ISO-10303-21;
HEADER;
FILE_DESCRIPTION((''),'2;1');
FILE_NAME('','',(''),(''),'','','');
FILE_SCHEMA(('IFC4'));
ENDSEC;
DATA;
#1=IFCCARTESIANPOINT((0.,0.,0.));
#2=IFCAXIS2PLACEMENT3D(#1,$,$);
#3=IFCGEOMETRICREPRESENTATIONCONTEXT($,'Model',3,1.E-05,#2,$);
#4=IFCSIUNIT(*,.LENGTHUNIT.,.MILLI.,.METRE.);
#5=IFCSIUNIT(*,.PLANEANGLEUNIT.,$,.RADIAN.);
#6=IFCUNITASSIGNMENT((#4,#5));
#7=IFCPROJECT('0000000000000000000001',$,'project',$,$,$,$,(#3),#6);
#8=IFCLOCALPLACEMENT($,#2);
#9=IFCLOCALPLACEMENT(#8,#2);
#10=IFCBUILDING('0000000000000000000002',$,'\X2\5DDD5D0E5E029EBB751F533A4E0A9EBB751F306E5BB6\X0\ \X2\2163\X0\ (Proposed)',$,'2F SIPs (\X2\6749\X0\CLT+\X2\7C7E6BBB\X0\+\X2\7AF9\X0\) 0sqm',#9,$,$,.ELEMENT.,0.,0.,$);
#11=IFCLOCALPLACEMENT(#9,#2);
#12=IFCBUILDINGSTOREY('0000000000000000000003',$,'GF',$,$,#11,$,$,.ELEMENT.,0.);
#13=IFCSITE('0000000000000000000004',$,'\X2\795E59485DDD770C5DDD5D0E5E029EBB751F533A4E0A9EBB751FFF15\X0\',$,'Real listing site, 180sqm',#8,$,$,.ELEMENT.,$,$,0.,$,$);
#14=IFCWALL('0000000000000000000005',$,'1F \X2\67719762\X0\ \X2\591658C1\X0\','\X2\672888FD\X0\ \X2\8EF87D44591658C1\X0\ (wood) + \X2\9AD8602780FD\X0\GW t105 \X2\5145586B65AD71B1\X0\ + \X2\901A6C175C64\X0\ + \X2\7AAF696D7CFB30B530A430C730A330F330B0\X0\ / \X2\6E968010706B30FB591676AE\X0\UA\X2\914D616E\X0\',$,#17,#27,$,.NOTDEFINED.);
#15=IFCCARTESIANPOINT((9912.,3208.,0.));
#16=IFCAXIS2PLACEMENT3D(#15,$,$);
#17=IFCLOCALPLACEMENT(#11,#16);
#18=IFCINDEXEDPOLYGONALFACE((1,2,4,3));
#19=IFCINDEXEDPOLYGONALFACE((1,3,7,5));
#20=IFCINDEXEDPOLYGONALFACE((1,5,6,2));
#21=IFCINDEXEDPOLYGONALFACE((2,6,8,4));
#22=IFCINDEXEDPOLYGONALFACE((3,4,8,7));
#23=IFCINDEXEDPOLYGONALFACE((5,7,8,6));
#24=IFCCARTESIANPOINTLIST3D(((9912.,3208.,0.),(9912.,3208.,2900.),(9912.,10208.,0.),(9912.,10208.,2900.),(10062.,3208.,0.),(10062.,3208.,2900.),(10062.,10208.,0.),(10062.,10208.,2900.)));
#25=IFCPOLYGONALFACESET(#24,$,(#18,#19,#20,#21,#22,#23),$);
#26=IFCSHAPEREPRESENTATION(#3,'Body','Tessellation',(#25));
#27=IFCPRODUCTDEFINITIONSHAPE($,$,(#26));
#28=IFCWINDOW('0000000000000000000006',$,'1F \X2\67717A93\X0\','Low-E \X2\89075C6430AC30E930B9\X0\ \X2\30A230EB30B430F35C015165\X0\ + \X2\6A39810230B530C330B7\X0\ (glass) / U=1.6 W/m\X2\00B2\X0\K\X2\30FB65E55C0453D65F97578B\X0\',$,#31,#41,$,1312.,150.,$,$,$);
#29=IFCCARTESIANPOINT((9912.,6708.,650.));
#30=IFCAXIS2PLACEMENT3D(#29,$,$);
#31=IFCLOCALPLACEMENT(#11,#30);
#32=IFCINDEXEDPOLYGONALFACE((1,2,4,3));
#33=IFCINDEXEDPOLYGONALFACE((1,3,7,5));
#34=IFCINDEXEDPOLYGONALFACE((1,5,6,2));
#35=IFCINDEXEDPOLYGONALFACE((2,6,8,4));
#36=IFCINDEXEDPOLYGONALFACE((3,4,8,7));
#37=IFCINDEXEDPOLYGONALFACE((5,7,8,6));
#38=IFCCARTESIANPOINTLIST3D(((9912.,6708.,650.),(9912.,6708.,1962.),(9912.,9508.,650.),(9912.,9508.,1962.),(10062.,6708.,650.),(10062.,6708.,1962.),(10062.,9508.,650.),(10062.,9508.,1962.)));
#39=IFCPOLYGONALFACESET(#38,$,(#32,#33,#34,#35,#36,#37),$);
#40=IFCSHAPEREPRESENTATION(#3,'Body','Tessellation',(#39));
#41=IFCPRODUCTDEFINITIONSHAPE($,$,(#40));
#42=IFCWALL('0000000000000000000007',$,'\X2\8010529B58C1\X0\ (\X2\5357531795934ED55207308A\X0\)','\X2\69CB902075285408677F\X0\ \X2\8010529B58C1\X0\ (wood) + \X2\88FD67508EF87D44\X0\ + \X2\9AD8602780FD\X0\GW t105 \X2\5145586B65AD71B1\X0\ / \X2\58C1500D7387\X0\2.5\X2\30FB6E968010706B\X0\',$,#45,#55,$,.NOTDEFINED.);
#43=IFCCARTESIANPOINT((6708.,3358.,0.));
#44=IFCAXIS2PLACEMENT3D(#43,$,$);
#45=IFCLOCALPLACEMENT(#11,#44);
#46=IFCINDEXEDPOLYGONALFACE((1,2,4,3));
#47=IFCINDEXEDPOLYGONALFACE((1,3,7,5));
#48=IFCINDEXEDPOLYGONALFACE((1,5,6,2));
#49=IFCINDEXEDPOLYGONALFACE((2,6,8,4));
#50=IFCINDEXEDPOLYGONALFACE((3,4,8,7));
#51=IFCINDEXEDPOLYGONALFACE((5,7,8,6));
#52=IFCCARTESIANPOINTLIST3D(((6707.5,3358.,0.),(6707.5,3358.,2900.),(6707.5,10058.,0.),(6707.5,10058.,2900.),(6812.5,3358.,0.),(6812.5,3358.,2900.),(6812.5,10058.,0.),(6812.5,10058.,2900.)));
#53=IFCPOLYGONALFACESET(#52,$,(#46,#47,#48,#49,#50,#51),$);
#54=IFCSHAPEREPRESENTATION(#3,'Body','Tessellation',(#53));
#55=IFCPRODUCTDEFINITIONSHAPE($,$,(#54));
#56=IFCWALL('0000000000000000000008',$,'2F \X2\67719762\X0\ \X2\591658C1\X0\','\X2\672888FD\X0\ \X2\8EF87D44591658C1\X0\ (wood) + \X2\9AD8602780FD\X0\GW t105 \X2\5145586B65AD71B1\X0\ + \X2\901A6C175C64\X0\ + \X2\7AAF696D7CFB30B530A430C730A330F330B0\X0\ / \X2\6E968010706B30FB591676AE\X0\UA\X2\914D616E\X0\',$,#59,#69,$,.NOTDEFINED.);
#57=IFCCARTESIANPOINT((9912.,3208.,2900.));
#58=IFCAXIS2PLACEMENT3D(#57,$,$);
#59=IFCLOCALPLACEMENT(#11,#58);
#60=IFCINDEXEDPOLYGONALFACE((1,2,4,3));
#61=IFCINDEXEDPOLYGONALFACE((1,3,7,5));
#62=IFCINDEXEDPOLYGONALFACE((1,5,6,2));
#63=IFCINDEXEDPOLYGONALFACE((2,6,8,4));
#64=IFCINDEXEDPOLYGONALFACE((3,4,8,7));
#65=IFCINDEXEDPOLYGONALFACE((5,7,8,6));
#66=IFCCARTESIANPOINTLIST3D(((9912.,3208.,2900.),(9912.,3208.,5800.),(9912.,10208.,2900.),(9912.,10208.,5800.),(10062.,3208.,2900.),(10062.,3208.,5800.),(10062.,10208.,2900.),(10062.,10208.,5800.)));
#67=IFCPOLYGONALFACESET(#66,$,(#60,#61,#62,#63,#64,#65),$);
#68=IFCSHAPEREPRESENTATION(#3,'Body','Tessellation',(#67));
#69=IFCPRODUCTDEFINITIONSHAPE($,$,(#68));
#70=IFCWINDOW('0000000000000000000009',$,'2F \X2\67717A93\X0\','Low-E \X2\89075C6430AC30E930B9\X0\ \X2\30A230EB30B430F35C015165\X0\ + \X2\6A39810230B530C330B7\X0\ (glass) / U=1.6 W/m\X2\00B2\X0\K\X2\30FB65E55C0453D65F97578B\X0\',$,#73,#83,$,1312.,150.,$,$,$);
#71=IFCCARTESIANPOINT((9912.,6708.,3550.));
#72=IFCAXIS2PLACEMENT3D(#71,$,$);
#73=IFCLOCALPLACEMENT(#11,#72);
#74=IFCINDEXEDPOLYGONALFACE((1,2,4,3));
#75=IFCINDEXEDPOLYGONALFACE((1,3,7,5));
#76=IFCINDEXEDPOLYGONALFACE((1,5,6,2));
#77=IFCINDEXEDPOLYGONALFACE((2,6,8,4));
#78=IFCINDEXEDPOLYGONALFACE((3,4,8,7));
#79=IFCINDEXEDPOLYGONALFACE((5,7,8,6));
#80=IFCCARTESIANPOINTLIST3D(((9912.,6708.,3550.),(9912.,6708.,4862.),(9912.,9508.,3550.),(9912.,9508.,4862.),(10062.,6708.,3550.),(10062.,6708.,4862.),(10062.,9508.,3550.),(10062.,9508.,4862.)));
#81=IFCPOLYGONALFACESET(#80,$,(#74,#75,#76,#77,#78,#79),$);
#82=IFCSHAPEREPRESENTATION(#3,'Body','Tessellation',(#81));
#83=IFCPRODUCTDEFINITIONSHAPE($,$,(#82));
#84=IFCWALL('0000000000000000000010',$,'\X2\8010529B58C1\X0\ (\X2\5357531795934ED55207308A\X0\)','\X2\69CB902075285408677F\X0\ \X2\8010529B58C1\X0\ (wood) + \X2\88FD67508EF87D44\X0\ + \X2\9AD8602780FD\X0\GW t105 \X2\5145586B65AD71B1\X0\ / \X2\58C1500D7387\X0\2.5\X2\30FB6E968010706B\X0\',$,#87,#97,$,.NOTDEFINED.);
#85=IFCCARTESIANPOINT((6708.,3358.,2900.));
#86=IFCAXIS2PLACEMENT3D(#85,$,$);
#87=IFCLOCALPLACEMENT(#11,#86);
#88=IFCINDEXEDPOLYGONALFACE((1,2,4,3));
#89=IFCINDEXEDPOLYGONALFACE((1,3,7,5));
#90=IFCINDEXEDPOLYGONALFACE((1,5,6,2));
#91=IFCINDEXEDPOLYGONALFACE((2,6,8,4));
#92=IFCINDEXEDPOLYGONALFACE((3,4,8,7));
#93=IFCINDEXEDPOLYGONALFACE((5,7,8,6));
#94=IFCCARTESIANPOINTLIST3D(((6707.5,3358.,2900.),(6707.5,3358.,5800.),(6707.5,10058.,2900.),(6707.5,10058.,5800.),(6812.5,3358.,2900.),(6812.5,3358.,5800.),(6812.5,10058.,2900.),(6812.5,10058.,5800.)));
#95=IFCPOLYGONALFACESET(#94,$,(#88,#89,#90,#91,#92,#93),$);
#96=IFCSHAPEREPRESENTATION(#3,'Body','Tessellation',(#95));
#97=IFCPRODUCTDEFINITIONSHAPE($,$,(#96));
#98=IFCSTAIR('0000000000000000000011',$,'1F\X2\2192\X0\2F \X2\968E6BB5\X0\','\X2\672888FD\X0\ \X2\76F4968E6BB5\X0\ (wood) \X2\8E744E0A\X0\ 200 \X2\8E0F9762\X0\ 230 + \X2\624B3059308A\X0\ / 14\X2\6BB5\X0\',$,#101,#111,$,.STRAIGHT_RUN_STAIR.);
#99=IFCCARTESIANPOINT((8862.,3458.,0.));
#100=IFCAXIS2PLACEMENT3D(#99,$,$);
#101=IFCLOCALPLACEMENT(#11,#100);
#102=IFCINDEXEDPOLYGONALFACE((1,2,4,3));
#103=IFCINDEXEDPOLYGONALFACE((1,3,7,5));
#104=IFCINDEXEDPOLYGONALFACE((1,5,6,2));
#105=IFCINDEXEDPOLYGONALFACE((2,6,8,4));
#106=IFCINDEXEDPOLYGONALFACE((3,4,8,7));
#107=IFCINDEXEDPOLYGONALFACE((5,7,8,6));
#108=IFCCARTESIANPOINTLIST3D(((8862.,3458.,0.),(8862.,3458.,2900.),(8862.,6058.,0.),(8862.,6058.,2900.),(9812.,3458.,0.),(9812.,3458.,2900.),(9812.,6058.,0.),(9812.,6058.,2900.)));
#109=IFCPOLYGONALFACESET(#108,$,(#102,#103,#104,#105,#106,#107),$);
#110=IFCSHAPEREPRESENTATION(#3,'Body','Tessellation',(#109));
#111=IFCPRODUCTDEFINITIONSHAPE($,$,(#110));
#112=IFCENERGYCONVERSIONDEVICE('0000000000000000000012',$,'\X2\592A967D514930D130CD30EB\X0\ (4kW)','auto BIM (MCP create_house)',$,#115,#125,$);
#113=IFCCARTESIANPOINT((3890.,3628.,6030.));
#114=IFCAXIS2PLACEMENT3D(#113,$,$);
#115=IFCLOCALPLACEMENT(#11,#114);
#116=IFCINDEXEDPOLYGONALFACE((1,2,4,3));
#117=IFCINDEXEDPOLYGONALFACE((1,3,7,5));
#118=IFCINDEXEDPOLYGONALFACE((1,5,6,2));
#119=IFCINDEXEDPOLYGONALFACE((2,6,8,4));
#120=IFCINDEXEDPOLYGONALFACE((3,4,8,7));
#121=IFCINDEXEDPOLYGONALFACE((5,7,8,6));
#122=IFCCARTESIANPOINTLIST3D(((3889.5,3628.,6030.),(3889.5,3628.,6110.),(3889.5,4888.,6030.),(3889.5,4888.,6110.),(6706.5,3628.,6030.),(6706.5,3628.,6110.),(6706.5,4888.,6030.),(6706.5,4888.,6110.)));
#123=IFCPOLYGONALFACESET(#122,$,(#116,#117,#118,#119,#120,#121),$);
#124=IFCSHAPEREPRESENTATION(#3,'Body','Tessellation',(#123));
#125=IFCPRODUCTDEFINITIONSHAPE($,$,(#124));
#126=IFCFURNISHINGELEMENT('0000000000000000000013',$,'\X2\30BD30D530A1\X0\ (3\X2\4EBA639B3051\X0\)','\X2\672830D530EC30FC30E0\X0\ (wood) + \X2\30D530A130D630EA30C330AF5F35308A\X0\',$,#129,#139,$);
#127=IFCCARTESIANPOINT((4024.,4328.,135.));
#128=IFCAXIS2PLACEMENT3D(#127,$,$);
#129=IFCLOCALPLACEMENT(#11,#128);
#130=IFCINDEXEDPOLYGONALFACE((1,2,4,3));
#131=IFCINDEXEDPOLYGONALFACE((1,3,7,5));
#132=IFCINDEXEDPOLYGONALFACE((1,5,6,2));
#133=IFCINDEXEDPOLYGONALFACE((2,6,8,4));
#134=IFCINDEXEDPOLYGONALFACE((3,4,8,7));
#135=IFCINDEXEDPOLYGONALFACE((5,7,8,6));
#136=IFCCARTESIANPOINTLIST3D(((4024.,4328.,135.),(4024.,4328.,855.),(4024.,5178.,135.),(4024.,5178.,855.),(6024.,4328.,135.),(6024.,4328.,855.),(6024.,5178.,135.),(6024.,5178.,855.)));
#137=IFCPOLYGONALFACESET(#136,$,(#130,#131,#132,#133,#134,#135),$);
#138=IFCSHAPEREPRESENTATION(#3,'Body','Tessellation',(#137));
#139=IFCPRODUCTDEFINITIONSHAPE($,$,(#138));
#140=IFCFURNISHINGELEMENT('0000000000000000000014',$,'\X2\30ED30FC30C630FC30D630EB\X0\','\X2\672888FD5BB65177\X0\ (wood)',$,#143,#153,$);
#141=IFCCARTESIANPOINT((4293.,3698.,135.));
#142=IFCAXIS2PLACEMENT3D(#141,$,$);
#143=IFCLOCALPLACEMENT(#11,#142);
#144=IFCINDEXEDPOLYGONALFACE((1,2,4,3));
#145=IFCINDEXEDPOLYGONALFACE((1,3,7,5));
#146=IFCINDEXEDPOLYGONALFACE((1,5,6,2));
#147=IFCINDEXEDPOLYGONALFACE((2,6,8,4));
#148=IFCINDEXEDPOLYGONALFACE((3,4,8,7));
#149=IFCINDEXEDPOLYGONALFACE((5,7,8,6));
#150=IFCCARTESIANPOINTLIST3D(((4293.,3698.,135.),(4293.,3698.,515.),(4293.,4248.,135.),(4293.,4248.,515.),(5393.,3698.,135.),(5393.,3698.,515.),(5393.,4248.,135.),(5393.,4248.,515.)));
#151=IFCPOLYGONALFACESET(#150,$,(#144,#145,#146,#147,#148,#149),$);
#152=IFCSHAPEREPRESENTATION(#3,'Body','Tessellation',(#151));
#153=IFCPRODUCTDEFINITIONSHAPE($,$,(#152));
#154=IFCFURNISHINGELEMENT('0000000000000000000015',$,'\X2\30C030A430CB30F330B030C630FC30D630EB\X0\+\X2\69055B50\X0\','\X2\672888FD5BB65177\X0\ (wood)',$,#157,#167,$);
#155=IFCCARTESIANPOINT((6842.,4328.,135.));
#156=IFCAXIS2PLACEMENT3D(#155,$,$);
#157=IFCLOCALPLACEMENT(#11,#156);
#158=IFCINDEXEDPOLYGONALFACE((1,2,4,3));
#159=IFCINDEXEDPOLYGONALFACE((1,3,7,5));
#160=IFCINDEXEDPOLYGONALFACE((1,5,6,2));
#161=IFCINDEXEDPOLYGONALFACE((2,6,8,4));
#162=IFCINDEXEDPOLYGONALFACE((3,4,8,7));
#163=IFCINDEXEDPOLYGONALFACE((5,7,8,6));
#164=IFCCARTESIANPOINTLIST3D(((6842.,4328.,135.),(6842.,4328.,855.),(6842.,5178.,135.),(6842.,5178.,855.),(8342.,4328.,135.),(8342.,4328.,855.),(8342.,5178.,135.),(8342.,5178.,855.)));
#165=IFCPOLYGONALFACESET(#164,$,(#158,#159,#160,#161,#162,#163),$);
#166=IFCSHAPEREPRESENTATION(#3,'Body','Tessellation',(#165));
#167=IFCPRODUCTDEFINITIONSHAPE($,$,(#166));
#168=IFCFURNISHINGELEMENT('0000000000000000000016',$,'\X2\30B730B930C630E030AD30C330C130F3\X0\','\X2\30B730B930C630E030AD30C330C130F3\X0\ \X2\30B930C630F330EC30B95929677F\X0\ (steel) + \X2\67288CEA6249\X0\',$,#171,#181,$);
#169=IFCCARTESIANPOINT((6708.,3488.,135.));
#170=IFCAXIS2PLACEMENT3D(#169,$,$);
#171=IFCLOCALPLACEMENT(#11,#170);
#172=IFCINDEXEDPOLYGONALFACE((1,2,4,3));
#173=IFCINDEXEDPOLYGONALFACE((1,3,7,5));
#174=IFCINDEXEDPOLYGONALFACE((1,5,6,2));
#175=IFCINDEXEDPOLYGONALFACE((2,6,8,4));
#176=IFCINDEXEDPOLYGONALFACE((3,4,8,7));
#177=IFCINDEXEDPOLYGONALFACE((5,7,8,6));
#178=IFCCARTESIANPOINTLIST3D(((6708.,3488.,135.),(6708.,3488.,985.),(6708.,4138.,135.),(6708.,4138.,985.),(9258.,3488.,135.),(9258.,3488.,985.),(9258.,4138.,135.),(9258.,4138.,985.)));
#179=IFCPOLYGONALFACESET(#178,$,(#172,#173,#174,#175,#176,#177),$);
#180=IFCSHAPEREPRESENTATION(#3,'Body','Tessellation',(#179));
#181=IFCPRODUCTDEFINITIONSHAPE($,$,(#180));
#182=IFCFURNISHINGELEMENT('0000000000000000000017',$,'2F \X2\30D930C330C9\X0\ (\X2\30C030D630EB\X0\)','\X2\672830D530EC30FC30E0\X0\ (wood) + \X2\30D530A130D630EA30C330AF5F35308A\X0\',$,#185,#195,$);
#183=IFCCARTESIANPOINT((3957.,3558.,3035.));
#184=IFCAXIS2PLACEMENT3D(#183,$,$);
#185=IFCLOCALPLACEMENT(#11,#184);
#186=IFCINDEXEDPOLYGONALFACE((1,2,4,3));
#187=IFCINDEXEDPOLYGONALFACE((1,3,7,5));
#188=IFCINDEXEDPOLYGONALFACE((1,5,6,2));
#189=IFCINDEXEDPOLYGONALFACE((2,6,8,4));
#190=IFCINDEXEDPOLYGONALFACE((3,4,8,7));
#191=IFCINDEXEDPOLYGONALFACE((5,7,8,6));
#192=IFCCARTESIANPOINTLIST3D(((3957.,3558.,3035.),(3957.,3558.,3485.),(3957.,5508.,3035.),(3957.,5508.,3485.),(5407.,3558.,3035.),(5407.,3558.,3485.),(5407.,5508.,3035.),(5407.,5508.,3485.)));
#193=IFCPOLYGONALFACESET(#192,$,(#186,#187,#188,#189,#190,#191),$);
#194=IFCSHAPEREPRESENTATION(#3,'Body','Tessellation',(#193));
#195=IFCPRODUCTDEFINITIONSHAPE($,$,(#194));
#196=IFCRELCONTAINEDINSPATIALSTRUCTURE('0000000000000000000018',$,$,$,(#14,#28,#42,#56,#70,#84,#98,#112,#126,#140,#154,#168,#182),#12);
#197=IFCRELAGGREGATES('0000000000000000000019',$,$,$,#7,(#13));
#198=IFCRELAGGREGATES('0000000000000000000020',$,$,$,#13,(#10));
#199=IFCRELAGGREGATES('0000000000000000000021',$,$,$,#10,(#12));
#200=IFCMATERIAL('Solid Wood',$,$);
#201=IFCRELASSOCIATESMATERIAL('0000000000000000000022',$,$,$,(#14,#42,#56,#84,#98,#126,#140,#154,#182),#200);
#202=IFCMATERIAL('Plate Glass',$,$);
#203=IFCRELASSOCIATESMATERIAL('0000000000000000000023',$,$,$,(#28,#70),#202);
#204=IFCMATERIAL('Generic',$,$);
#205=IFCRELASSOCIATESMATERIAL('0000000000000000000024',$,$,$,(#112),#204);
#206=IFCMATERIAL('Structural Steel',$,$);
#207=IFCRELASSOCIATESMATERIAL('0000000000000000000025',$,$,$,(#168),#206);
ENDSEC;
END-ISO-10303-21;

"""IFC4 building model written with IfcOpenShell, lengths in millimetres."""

from ifc_helpers import new_model, si_unit, frame, frame_2d, origin, place, context, project, spatial, rectangle, extrude, material, element, fill, save


model = new_model("IFC4")

# Units and contexts
model_context = context("Model", 3, precision=1e-05, world=origin())
ifc_project = project(units=[si_unit("LENGTHUNIT", "METRE", prefix="MILLI"), si_unit("PLANEANGLEUNIT", "RADIAN")], contexts=[model_context])

# Site, building, storey
site_placement = place(None, origin())
site = spatial("IfcSite", under=ifc_project, at=site_placement, Name="神奈川県川崎市麻生区上麻生５", ObjectType="Real listing site, 180sqm", CompositionType="ELEMENT", RefElevation=0.0)
building_placement = place(site_placement, origin())
building = spatial("IfcBuilding", under=site, at=building_placement, Name="川崎市麻生区上麻生の家 Ⅳ (Proposed)", ObjectType="2F SIPs (杉CLT+籾殻+竹) 0sqm", CompositionType="ELEMENT", ElevationOfRefHeight=0.0, ElevationOfTerrain=0.0)
storey_placement = place(building_placement, origin())
storey = spatial("IfcBuildingStorey", under=building, at=storey_placement, Name="GF", CompositionType="ELEMENT", Elevation=0.0)

# Wall, opening, window
ifc_material_1 = material(Name="Solid Wood")
wall_1_placement = place(storey_placement, frame((9912.0, 3208.0, 0.0)))
wall_1 = element("IfcWall", 1, at=wall_1_placement, inside=storey, material=ifc_material_1, Name="1F 東面 外壁", Description="木製 軸組外壁 (wood) + 高性能GW t105 充填断熱 + 通気層 + 窯業系サイディング / 準耐火・外皮UA配慮", PredefinedType="NOTDEFINED", context=model_context, shape_type="SweptSolid", body=[
    extrude(rectangle(XDim=150.0, YDim=7000.0, at=frame_2d((75.0, 3500.0))), frame((9912.0, 3208.0, 0.0)), (0.0, 0.0, 1.0), 2900.0),
])
opening_1_placement = place(storey_placement, frame((9912.0, 6708.0, 650.0)))
opening_1 = element("IfcOpeningElement", 2, at=opening_1_placement, cuts=wall_1, PredefinedType="NOTDEFINED", context=model_context, shape_type="SweptSolid", body=[
    extrude(rectangle(XDim=150.0, YDim=2800.0, at=frame_2d((75.0, 1400.0))), frame((9912.0, 6708.0, 650.0)), (0.0, 0.0, 1.0), 1312.0),
])
ifc_material_2 = material(Name="Plate Glass")
window_1_placement = place(storey_placement, frame((9912.0, 6708.0, 650.0)))
window_1 = element("IfcWindow", 3, at=window_1_placement, inside=storey, material=ifc_material_2, Name="1F 東窓", Description="Low-E 複層ガラス アルゴン封入 + 樹脂サッシ (glass) / U=1.6 W/m²K・日射取得型", OverallHeight=1312.0, OverallWidth=150.0, context=model_context, shape_type="SweptSolid", body=[
    extrude(rectangle(XDim=150.0, YDim=2800.0, at=frame_2d((75.0, 1400.0))), frame((9912.0, 6708.0, 650.0)), (0.0, 0.0, 1.0), 1312.0),
])
fill(opening_1, window_1)

# Wall
wall_2_placement = place(storey_placement, frame((6708.0, 3358.0, 0.0)))
element("IfcWall", 4, at=wall_2_placement, inside=storey, material=ifc_material_1, Name="耐力壁 (南北間仕切り)", Description="構造用合板 耐力壁 (wood) + 製材軸組 + 高性能GW t105 充填断熱 / 壁倍率2.5・準耐火", PredefinedType="NOTDEFINED", context=model_context, shape_type="SweptSolid", body=[
    extrude(rectangle(XDim=105.0, YDim=6700.0, at=frame_2d((52.0, 3350.0))), frame((6708.0, 3358.0, 0.0)), (0.0, 0.0, 1.0), 2900.0),
])

# Wall, opening, window
wall_3_placement = place(storey_placement, frame((9912.0, 3208.0, 2900.0)))
wall_3 = element("IfcWall", 5, at=wall_3_placement, inside=storey, material=ifc_material_1, Name="2F 東面 外壁", Description="木製 軸組外壁 (wood) + 高性能GW t105 充填断熱 + 通気層 + 窯業系サイディング / 準耐火・外皮UA配慮", PredefinedType="NOTDEFINED", context=model_context, shape_type="SweptSolid", body=[
    extrude(rectangle(XDim=150.0, YDim=7000.0, at=frame_2d((75.0, 3500.0))), frame((9912.0, 3208.0, 2900.0)), (0.0, 0.0, 1.0), 2900.0),
])
opening_2_placement = place(storey_placement, frame((9912.0, 6708.0, 3550.0)))
opening_2 = element("IfcOpeningElement", 6, at=opening_2_placement, cuts=wall_3, PredefinedType="NOTDEFINED", context=model_context, shape_type="SweptSolid", body=[
    extrude(rectangle(XDim=150.0, YDim=2800.0, at=frame_2d((75.0, 1400.0))), frame((9912.0, 6708.0, 3550.0)), (0.0, 0.0, 1.0), 1312.0),
])
window_2_placement = place(storey_placement, frame((9912.0, 6708.0, 3550.0)))
window_2 = element("IfcWindow", 7, at=window_2_placement, inside=storey, material=ifc_material_2, Name="2F 東窓", Description="Low-E 複層ガラス アルゴン封入 + 樹脂サッシ (glass) / U=1.6 W/m²K・日射取得型", OverallHeight=1312.0, OverallWidth=150.0, context=model_context, shape_type="SweptSolid", body=[
    extrude(rectangle(XDim=150.0, YDim=2800.0, at=frame_2d((75.0, 1400.0))), frame((9912.0, 6708.0, 3550.0)), (0.0, 0.0, 1.0), 1312.0),
])
fill(opening_2, window_2)

# Wall
wall_4_placement = place(storey_placement, frame((6708.0, 3358.0, 2900.0)))
element("IfcWall", 8, at=wall_4_placement, inside=storey, material=ifc_material_1, Name="耐力壁 (南北間仕切り)", Description="構造用合板 耐力壁 (wood) + 製材軸組 + 高性能GW t105 充填断熱 / 壁倍率2.5・準耐火", PredefinedType="NOTDEFINED", context=model_context, shape_type="SweptSolid", body=[
    extrude(rectangle(XDim=105.0, YDim=6700.0, at=frame_2d((52.0, 3350.0))), frame((6708.0, 3358.0, 2900.0)), (0.0, 0.0, 1.0), 2900.0),
])

# Stair
stair_placement = place(storey_placement, frame((8862.0, 3458.0, 0.0)))
element("IfcStair", 9, at=stair_placement, inside=storey, material=ifc_material_1, Name="1F→2F 階段", Description="木製 直階段 (wood) 蹴上 200 踏面 230 + 手すり / 14段", PredefinedType="STRAIGHT_RUN_STAIR", context=model_context, shape_type="SweptSolid", body=[
    extrude(rectangle(XDim=950.0, YDim=2600.0, at=frame_2d((475.0, 1300.0))), frame((8862.0, 3458.0, 0.0)), (0.0, 0.0, 1.0), 2900.0),
])

# Energy conversion device
ifc_material_3 = material(Name="Generic")
energy_conversion_device_placement = place(storey_placement, frame((3890.0, 3628.0, 6030.0)))
element("IfcEnergyConversionDevice", 10, at=energy_conversion_device_placement, inside=storey, material=ifc_material_3, Name="太陽光パネル (4kW)", Description="auto BIM (MCP create_house)", context=model_context, shape_type="SweptSolid", body=[
    extrude(rectangle(XDim=2817.0, YDim=1260.0, at=frame_2d((1408.0, 630.0))), frame((3890.0, 3628.0, 6030.0)), (0.0, 0.0, 1.0), 80.0),
])

# Furnishing elements
furnishing_1_placement = place(storey_placement, frame((4024.0, 4328.0, 135.0)))
element("IfcFurnishingElement", 11, at=furnishing_1_placement, inside=storey, material=ifc_material_1, Name="ソファ (3人掛け)", Description="木フレーム (wood) + ファブリック張り", context=model_context, shape_type="SweptSolid", body=[
    extrude(rectangle(XDim=2000.0, YDim=850.0, at=frame_2d((1000.0, 425.0))), frame((4024.0, 4328.0, 135.0)), (0.0, 0.0, 1.0), 720.0),
])
furnishing_2_placement = place(storey_placement, frame((4293.0, 3698.0, 135.0)))
element("IfcFurnishingElement", 12, at=furnishing_2_placement, inside=storey, material=ifc_material_1, Name="ローテーブル", Description="木製家具 (wood)", context=model_context, shape_type="SweptSolid", body=[
    extrude(rectangle(XDim=1100.0, YDim=550.0, at=frame_2d((550.0, 275.0))), frame((4293.0, 3698.0, 135.0)), (0.0, 0.0, 1.0), 380.0),
])
furnishing_3_placement = place(storey_placement, frame((6842.0, 4328.0, 135.0)))
element("IfcFurnishingElement", 13, at=furnishing_3_placement, inside=storey, material=ifc_material_1, Name="ダイニングテーブル+椅子", Description="木製家具 (wood)", context=model_context, shape_type="SweptSolid", body=[
    extrude(rectangle(XDim=1500.0, YDim=850.0, at=frame_2d((750.0, 425.0))), frame((6842.0, 4328.0, 135.0)), (0.0, 0.0, 1.0), 720.0),
])
ifc_material_4 = material(Name="Structural Steel")
furnishing_4_placement = place(storey_placement, frame((6708.0, 3488.0, 135.0)))
element("IfcFurnishingElement", 14, at=furnishing_4_placement, inside=storey, material=ifc_material_4, Name="システムキッチン", Description="システムキッチン ステンレス天板 (steel) + 木質扉", context=model_context, shape_type="SweptSolid", body=[
    extrude(rectangle(XDim=2550.0, YDim=650.0, at=frame_2d((1275.0, 325.0))), frame((6708.0, 3488.0, 135.0)), (0.0, 0.0, 1.0), 850.0),
])
furnishing_5_placement = place(storey_placement, frame((3957.0, 3558.0, 3035.0)))
element("IfcFurnishingElement", 15, at=furnishing_5_placement, inside=storey, material=ifc_material_1, Name="2F ベッド (ダブル)", Description="木フレーム (wood) + ファブリック張り", context=model_context, shape_type="SweptSolid", body=[
    extrude(rectangle(XDim=1450.0, YDim=1950.0, at=frame_2d((725.0, 975.0))), frame((3957.0, 3558.0, 3035.0)), (0.0, 0.0, 1.0), 450.0),
])

save(model, "model.ifc")
